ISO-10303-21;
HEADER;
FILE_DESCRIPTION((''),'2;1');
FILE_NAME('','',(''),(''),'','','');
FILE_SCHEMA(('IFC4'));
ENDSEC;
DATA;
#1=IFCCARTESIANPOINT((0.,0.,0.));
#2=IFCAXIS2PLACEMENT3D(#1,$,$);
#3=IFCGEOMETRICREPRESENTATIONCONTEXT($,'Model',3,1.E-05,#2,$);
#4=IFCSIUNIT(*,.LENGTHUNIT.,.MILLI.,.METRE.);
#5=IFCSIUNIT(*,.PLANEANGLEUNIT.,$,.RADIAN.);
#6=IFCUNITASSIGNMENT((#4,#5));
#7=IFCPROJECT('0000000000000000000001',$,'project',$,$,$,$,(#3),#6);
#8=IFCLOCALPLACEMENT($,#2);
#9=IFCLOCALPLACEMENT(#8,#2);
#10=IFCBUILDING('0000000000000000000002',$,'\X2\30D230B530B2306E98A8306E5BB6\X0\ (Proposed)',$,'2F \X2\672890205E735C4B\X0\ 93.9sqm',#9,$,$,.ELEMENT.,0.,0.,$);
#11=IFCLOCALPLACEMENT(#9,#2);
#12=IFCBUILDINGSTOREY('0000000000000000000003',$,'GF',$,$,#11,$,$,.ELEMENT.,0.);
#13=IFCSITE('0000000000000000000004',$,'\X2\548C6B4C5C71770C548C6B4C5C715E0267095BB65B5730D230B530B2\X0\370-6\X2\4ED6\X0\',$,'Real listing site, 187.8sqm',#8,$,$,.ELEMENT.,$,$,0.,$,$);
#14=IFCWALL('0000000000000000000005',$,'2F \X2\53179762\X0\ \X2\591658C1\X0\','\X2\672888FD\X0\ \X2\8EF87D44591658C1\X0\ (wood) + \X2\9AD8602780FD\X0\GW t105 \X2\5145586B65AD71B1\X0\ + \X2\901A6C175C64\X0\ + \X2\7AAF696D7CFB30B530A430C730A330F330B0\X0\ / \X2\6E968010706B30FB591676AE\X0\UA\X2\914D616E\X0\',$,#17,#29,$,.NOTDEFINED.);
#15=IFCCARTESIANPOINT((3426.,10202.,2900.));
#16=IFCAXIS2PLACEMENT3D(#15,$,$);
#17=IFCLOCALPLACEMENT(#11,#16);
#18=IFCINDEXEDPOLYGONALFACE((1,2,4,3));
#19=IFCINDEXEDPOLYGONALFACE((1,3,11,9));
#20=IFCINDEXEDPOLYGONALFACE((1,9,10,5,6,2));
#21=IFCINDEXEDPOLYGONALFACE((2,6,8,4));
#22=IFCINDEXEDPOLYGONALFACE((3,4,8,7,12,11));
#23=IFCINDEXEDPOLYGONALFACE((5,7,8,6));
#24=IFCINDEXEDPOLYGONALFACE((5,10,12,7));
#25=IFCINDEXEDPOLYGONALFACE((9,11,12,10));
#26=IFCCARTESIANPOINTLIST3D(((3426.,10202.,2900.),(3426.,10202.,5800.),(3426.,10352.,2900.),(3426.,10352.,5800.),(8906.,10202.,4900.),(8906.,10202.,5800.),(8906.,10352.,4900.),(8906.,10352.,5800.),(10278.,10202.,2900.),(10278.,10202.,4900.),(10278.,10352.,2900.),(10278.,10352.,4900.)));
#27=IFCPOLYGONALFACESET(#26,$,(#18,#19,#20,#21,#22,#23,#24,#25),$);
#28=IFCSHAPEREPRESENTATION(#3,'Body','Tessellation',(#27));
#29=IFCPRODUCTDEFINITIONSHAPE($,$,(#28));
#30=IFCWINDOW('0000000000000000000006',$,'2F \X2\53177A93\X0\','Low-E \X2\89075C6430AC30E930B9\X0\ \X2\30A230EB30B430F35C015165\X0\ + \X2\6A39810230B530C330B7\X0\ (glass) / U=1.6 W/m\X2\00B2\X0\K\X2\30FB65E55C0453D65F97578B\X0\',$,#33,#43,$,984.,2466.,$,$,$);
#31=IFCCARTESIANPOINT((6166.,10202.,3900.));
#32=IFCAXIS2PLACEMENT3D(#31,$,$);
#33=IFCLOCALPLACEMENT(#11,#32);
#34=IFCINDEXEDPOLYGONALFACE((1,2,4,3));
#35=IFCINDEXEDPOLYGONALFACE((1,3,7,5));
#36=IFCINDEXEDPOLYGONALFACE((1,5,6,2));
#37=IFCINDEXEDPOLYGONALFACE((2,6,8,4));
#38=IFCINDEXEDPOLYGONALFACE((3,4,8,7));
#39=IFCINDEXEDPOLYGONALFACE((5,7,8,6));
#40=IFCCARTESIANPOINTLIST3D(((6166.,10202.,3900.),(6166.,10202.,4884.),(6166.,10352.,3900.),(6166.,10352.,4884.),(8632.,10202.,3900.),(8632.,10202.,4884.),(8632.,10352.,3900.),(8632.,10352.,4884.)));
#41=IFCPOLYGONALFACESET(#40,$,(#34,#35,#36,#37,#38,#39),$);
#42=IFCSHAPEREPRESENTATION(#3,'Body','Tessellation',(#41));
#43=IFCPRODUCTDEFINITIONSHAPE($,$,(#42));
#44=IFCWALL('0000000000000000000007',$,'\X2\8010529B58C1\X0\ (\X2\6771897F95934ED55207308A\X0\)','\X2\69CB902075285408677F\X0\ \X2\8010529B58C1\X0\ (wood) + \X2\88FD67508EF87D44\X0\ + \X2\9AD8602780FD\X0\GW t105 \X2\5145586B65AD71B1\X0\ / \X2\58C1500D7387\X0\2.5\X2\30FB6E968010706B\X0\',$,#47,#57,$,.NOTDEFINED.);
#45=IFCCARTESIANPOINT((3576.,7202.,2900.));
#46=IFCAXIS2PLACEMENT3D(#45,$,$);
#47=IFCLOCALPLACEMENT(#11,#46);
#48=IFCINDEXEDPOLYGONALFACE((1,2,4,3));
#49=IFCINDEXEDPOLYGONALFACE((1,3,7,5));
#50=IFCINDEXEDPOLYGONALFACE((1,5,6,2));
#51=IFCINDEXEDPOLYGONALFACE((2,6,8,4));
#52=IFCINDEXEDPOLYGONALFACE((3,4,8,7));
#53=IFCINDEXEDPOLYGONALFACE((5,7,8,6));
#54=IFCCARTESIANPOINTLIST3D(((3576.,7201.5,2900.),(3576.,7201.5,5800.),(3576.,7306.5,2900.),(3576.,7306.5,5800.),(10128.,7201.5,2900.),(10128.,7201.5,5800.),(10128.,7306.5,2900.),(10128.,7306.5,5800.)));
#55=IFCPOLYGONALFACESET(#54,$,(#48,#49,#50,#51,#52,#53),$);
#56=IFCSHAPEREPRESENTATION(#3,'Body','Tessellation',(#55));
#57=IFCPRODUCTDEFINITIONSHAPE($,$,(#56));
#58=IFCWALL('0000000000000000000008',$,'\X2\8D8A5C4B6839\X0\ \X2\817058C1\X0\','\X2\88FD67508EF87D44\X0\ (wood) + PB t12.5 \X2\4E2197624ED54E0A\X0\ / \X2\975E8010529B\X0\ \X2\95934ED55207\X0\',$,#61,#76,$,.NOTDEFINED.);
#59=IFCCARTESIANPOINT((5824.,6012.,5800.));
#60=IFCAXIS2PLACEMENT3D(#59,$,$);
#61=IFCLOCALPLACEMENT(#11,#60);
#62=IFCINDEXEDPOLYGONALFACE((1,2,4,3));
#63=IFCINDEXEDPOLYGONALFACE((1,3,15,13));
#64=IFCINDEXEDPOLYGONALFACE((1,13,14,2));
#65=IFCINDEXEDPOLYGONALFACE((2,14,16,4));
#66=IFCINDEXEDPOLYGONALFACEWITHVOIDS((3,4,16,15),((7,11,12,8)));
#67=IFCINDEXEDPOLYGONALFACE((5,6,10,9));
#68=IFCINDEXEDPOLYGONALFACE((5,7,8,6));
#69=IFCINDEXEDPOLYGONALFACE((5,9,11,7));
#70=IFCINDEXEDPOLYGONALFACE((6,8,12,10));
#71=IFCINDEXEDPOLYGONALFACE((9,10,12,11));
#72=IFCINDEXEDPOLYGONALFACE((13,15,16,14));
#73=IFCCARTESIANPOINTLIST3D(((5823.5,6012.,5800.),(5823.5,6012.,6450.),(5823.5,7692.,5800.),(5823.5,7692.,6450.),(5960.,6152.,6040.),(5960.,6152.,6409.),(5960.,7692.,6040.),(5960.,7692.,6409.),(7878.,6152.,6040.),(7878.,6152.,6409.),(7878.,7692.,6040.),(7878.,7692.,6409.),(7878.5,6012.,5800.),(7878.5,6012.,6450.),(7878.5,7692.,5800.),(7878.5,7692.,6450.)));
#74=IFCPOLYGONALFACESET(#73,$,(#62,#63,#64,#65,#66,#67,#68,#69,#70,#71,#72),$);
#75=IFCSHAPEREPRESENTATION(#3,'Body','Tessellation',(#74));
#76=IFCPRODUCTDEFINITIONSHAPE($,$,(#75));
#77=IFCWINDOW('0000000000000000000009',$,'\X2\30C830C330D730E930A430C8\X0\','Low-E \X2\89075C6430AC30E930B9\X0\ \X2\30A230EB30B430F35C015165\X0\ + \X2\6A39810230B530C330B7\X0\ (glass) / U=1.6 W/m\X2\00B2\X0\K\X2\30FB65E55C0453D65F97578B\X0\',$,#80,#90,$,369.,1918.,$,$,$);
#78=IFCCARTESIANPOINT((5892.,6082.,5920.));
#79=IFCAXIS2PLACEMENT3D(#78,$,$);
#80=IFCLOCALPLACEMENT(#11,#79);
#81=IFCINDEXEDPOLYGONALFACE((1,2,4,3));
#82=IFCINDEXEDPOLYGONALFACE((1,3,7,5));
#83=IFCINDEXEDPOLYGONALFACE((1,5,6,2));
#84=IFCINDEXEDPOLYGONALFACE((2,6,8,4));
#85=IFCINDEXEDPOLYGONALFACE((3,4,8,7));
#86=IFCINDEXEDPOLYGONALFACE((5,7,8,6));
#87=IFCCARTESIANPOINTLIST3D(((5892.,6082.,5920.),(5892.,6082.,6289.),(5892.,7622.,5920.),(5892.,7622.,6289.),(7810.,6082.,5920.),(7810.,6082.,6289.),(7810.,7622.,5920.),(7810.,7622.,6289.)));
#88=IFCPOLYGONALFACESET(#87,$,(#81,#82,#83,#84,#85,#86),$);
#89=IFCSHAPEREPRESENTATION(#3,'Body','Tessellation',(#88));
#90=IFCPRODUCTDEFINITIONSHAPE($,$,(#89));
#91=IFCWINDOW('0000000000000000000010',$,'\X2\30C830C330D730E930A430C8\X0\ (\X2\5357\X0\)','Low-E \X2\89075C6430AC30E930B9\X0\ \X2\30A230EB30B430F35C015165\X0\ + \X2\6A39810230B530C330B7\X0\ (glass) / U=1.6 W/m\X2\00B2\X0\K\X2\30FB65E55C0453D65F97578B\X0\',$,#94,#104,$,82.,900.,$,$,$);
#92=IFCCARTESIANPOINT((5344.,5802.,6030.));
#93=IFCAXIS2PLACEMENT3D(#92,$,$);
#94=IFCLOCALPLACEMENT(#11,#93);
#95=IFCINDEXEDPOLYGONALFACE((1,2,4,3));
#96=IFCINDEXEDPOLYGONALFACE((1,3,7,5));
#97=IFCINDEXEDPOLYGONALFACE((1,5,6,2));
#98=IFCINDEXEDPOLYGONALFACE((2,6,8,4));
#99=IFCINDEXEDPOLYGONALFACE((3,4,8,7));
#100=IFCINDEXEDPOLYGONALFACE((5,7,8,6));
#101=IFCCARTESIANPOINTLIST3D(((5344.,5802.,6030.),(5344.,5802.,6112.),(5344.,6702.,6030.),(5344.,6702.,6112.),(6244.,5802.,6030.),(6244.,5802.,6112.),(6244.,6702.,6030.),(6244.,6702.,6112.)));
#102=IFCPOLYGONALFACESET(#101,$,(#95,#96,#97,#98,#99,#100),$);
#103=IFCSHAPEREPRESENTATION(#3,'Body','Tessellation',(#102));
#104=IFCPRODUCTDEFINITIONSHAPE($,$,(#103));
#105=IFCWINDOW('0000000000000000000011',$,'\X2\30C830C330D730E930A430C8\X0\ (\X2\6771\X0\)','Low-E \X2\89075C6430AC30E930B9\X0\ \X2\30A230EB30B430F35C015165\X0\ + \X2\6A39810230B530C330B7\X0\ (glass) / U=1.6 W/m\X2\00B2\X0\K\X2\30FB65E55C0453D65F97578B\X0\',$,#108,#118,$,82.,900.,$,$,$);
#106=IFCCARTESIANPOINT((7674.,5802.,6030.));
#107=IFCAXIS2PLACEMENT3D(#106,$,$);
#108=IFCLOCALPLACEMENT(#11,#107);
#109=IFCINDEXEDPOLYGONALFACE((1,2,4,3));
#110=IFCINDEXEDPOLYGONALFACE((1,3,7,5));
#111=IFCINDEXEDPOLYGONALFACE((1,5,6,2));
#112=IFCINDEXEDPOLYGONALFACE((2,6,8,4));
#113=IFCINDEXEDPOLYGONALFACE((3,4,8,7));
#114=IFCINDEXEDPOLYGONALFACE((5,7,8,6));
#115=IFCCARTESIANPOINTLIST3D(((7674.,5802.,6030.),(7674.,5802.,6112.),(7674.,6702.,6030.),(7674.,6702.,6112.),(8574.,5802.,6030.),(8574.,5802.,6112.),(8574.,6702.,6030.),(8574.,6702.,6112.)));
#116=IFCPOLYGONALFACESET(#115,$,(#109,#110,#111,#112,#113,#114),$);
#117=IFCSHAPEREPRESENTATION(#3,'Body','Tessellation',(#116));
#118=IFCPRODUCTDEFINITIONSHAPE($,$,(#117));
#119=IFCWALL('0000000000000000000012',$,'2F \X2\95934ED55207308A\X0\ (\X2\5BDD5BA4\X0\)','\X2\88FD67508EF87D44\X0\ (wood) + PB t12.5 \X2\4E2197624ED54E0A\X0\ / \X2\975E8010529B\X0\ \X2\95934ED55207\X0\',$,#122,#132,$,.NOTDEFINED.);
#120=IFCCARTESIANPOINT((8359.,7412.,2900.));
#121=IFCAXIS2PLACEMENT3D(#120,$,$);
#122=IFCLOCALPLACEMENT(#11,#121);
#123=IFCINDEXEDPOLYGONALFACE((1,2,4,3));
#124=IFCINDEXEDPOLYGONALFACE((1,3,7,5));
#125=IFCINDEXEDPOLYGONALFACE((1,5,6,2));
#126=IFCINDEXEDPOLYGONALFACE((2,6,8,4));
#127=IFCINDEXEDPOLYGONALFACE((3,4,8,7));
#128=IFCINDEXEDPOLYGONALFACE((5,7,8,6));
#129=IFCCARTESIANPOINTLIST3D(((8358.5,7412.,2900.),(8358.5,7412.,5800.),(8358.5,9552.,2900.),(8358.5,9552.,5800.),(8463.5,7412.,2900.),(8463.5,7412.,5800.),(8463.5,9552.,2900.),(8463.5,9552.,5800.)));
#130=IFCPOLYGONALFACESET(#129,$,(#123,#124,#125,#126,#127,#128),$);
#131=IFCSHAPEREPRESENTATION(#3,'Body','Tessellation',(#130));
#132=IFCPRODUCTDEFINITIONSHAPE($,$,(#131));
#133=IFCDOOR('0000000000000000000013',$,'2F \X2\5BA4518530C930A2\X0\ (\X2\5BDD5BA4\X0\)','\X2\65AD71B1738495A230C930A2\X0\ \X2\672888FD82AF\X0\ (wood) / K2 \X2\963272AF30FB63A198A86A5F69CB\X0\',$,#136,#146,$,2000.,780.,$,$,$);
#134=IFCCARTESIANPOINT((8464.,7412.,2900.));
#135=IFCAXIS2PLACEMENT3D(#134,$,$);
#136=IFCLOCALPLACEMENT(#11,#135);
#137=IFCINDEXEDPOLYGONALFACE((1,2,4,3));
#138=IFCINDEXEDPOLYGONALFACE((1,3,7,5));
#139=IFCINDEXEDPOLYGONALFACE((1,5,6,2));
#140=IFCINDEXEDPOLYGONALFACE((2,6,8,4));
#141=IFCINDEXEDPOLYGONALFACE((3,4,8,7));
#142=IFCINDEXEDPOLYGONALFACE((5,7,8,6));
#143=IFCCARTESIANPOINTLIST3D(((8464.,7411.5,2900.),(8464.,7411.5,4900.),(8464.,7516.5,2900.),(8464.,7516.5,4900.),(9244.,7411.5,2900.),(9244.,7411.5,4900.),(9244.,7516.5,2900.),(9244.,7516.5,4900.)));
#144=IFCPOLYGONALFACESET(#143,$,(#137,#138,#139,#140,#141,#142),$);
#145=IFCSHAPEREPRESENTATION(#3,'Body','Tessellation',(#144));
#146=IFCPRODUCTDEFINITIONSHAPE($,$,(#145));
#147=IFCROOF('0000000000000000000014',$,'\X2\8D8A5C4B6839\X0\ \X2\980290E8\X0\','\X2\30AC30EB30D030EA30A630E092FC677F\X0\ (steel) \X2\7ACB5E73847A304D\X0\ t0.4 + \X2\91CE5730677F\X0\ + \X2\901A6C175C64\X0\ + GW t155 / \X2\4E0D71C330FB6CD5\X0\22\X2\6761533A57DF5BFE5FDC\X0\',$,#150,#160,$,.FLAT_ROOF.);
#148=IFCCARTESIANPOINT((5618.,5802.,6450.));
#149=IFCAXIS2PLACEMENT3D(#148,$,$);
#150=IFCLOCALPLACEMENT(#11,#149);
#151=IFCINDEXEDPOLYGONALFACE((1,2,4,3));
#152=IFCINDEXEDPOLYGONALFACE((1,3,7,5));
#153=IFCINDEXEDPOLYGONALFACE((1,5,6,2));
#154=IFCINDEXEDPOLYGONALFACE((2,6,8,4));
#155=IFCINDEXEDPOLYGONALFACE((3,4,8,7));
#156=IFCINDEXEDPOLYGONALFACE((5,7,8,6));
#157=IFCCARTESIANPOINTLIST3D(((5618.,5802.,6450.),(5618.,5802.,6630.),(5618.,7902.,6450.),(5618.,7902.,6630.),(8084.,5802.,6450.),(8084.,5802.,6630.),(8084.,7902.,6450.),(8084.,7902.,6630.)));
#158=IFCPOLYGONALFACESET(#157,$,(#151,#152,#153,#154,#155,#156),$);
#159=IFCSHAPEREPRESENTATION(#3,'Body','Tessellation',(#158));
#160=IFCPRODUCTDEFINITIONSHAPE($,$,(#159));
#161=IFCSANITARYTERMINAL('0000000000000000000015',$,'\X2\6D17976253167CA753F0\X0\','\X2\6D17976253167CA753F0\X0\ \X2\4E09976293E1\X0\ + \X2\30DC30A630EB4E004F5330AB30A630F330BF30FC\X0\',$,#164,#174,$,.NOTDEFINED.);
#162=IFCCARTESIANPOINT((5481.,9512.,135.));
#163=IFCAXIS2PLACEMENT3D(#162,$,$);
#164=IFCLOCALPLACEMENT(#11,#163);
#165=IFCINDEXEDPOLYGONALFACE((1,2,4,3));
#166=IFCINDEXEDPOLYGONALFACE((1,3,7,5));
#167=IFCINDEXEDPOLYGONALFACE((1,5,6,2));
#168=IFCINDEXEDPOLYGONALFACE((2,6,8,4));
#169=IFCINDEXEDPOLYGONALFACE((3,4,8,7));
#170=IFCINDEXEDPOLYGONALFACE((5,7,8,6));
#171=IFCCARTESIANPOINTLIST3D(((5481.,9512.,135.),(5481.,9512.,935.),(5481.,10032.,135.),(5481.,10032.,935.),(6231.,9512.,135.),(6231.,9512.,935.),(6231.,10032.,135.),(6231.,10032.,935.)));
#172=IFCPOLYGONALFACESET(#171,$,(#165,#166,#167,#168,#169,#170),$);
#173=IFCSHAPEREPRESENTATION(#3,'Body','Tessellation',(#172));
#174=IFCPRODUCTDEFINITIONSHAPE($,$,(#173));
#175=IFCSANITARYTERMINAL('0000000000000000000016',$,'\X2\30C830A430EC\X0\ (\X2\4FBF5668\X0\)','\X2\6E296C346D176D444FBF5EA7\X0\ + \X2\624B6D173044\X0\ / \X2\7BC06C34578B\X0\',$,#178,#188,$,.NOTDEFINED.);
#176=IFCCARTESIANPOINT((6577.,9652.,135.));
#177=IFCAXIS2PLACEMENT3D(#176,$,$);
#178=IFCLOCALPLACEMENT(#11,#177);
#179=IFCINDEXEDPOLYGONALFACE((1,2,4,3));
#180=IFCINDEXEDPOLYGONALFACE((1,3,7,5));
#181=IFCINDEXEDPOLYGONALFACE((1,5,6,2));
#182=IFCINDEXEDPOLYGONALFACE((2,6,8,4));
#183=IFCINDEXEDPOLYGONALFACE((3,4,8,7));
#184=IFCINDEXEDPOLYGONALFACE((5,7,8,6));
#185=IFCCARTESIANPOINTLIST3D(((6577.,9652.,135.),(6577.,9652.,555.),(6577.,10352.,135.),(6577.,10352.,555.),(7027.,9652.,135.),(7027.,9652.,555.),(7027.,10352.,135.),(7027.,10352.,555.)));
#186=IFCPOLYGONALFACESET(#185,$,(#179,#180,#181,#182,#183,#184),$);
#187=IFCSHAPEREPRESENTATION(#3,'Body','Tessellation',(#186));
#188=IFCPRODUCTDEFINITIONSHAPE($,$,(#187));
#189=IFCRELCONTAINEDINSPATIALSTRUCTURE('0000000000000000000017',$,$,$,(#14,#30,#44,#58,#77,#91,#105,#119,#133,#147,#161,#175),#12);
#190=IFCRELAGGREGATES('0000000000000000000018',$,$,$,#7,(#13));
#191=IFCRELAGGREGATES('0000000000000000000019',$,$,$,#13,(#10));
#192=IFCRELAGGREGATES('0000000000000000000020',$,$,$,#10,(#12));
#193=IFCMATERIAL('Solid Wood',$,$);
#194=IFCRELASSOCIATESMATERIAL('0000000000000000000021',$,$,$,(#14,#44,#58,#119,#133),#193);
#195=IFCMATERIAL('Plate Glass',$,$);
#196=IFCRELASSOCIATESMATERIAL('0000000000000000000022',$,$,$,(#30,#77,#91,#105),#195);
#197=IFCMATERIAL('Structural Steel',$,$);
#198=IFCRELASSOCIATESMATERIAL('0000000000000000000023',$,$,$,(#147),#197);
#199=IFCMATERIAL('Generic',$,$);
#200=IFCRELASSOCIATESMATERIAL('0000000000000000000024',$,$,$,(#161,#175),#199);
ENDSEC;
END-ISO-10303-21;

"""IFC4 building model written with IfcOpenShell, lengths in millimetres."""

from ifc_helpers import new_model, si_unit, frame, frame_2d, origin, place, context, project, spatial, rectangle, extrude, material, element, fill, save


model = new_model("IFC4")

# Units and contexts
model_context = context("Model", 3, precision=1e-05, world=origin())
ifc_project = project(units=[si_unit("LENGTHUNIT", "METRE", prefix="MILLI"), si_unit("PLANEANGLEUNIT", "RADIAN")], contexts=[model_context])

# Site, building, storey
site_placement = place(None, origin())
site = spatial("IfcSite", under=ifc_project, at=site_placement, Name="和歌山県和歌山市有家字ヒサゲ370-6他", ObjectType="Real listing site, 187.8sqm", CompositionType="ELEMENT", RefElevation=0.0)
building_placement = place(site_placement, origin())
building = spatial("IfcBuilding", under=site, at=building_placement, Name="ヒサゲの風の家 (Proposed)", ObjectType="2F 木造平屋 93.9sqm", CompositionType="ELEMENT", ElevationOfRefHeight=0.0, ElevationOfTerrain=0.0)
storey_placement = place(building_placement, origin())
storey = spatial("IfcBuildingStorey", under=building, at=storey_placement, Name="GF", CompositionType="ELEMENT", Elevation=0.0)

# Wall, opening, window
ifc_material_1 = material(Name="Solid Wood")
wall_1_placement = place(storey_placement, frame((3426.0, 10202.0, 2900.0)))
wall_1 = element("IfcWall", 1, at=wall_1_placement, inside=storey, material=ifc_material_1, Name="2F 北面 外壁", Description="木製 軸組外壁 (wood) + 高性能GW t105 充填断熱 + 通気層 + 窯業系サイディング / 準耐火・外皮UA配慮", PredefinedType="NOTDEFINED", context=model_context, shape_type="SweptSolid", body=[
    extrude(rectangle(XDim=6852.0, YDim=150.0, at=frame_2d((3426.0, 75.0))), frame((3426.0, 10202.0, 2900.0)), (0.0, 0.0, 1.0), 2900.0),
])
opening_1_placement = place(storey_placement, frame((6166.0, 10202.0, 3900.0)))
opening_1 = element("IfcOpeningElement", 2, at=opening_1_placement, cuts=wall_1, PredefinedType="NOTDEFINED", context=model_context, shape_type="SweptSolid", body=[
    extrude(rectangle(XDim=2466.0, YDim=150.0, at=frame_2d((1233.0, 75.0))), frame((6166.0, 10202.0, 3900.0)), (0.0, 0.0, 1.0), 984.0),
])
ifc_material_2 = material(Name="Plate Glass")
window_1_placement = place(storey_placement, frame((6166.0, 10202.0, 3900.0)))
window_1 = element("IfcWindow", 3, at=window_1_placement, inside=storey, material=ifc_material_2, Name="2F 北窓", Description="Low-E 複層ガラス アルゴン封入 + 樹脂サッシ (glass) / U=1.6 W/m²K・日射取得型", OverallHeight=984.0, OverallWidth=2466.0, context=model_context, shape_type="SweptSolid", body=[
    extrude(rectangle(XDim=2466.0, YDim=150.0, at=frame_2d((1233.0, 75.0))), frame((6166.0, 10202.0, 3900.0)), (0.0, 0.0, 1.0), 984.0),
])
fill(opening_1, window_1)

# Wall
wall_2_placement = place(storey_placement, frame((3576.0, 7202.0, 2900.0)))
element("IfcWall", 4, at=wall_2_placement, inside=storey, material=ifc_material_1, Name="耐力壁 (東西間仕切り)", Description="構造用合板 耐力壁 (wood) + 製材軸組 + 高性能GW t105 充填断熱 / 壁倍率2.5・準耐火", PredefinedType="NOTDEFINED", context=model_context, shape_type="SweptSolid", body=[
    extrude(rectangle(XDim=6552.0, YDim=105.0, at=frame_2d((3276.0, 52.0))), frame((3576.0, 7202.0, 2900.0)), (0.0, 0.0, 1.0), 2900.0),
])

# Wall, openings, windows
wall_3_placement = place(storey_placement, frame((5824.0, 6012.0, 5800.0)))
wall_3 = element("IfcWall", 5, at=wall_3_placement, inside=storey, material=ifc_material_1, Name="越屋根 腰壁", Description="製材軸組 (wood) + PB t12.5 両面仕上 / 非耐力 間仕切", PredefinedType="NOTDEFINED", context=model_context, shape_type="SweptSolid", body=[
    extrude(rectangle(XDim=2055.0, YDim=1680.0, at=frame_2d((1027.0, 840.0))), frame((5824.0, 6012.0, 5800.0)), (0.0, 0.0, 1.0), 650.0),
])
opening_2_placement = place(storey_placement, frame((5892.0, 6082.0, 5920.0)))
opening_2 = element("IfcOpeningElement", 6, at=opening_2_placement, cuts=wall_3, PredefinedType="NOTDEFINED", context=model_context, shape_type="SweptSolid", body=[
    extrude(rectangle(XDim=1918.0, YDim=1540.0, at=frame_2d((959.0, 770.0))), frame((5892.0, 6082.0, 5920.0)), (0.0, 0.0, 1.0), 369.0),
])
opening_3_placement = place(storey_placement, frame((5344.0, 5802.0, 6030.0)))
opening_3 = element("IfcOpeningElement", 7, at=opening_3_placement, cuts=wall_3, PredefinedType="NOTDEFINED", context=model_context, shape_type="SweptSolid", body=[
    extrude(rectangle(XDim=900.0, YDim=900.0, at=frame_2d((450.0, 450.0))), frame((5344.0, 5802.0, 6030.0)), (0.0, 0.0, 1.0), 82.0),
])
opening_4_placement = place(storey_placement, frame((7674.0, 5802.0, 6030.0)))
opening_4 = element("IfcOpeningElement", 8, at=opening_4_placement, cuts=wall_3, PredefinedType="NOTDEFINED", context=model_context, shape_type="SweptSolid", body=[
    extrude(rectangle(XDim=900.0, YDim=900.0, at=frame_2d((450.0, 450.0))), frame((7674.0, 5802.0, 6030.0)), (0.0, 0.0, 1.0), 82.0),
])
window_2_placement = place(storey_placement, frame((5892.0, 6082.0, 5920.0)))
window_2 = element("IfcWindow", 9, at=window_2_placement, inside=storey, material=ifc_material_2, Name="トップライト", Description="Low-E 複層ガラス アルゴン封入 + 樹脂サッシ (glass) / U=1.6 W/m²K・日射取得型", OverallHeight=369.0, OverallWidth=1918.0, context=model_context, shape_type="SweptSolid", body=[
    extrude(rectangle(XDim=1918.0, YDim=1540.0, at=frame_2d((959.0, 770.0))), frame((5892.0, 6082.0, 5920.0)), (0.0, 0.0, 1.0), 369.0),
])
fill(opening_2, window_2)
window_3_placement = place(storey_placement, frame((5344.0, 5802.0, 6030.0)))
window_3 = element("IfcWindow", 10, at=window_3_placement, inside=storey, material=ifc_material_2, Name="トップライト (南)", Description="Low-E 複層ガラス アルゴン封入 + 樹脂サッシ (glass) / U=1.6 W/m²K・日射取得型", OverallHeight=82.0, OverallWidth=900.0, context=model_context, shape_type="SweptSolid", body=[
    extrude(rectangle(XDim=900.0, YDim=900.0, at=frame_2d((450.0, 450.0))), frame((5344.0, 5802.0, 6030.0)), (0.0, 0.0, 1.0), 82.0),
])
fill(opening_3, window_3)
window_4_placement = place(storey_placement, frame((7674.0, 5802.0, 6030.0)))
window_4 = element("IfcWindow", 11, at=window_4_placement, inside=storey, material=ifc_material_2, Name="トップライト (東)", Description="Low-E 複層ガラス アルゴン封入 + 樹脂サッシ (glass) / U=1.6 W/m²K・日射取得型", OverallHeight=82.0, OverallWidth=900.0, context=model_context, shape_type="SweptSolid", body=[
    extrude(rectangle(XDim=900.0, YDim=900.0, at=frame_2d((450.0, 450.0))), frame((7674.0, 5802.0, 6030.0)), (0.0, 0.0, 1.0), 82.0),
])
fill(opening_4, window_4)

# Wall
wall_4_placement = place(storey_placement, frame((8359.0, 7412.0, 2900.0)))
element("IfcWall", 12, at=wall_4_placement, inside=storey, material=ifc_material_1, Name="2F 間仕切り (寝室)", Description="製材軸組 (wood) + PB t12.5 両面仕上 / 非耐力 間仕切", PredefinedType="NOTDEFINED", context=model_context, shape_type="SweptSolid", body=[
    extrude(rectangle(XDim=105.0, YDim=2140.0, at=frame_2d((52.0, 1070.0))), frame((8359.0, 7412.0, 2900.0)), (0.0, 0.0, 1.0), 2900.0),
])

# Door
door_placement = place(storey_placement, frame((8464.0, 7412.0, 2900.0)))
element("IfcDoor", 13, at=door_placement, inside=storey, material=ifc_material_1, Name="2F 室内ドア (寝室)", Description="断熱玄関ドア 木製芯 (wood) / K2 防犯・採風機構", OverallHeight=2000.0, OverallWidth=780.0, context=model_context, shape_type="SweptSolid", body=[
    extrude(rectangle(XDim=780.0, YDim=105.0, at=frame_2d((390.0, 52.0))), frame((8464.0, 7412.0, 2900.0)), (0.0, 0.0, 1.0), 2000.0),
])

# Roof
ifc_material_3 = material(Name="Structural Steel")
roof_placement = place(storey_placement, frame((5618.0, 5802.0, 6450.0)))
element("IfcRoof", 14, at=roof_placement, inside=storey, material=ifc_material_3, Name="越屋根 頂部", Description="ガルバリウム鋼板 (steel) 立平葺き t0.4 + 野地板 + 通気層 + GW t155 / 不燃・法22条区域対応", PredefinedType="FLAT_ROOF", context=model_context, shape_type="SweptSolid", body=[
    extrude(rectangle(XDim=2466.0, YDim=2100.0, at=frame_2d((1233.0, 1050.0))), frame((5618.0, 5802.0, 6450.0)), (0.0, 0.0, 1.0), 180.0),
])

# Sanitary terminals
ifc_material_4 = material(Name="Generic")
sanitary_terminal_1_placement = place(storey_placement, frame((5481.0, 9512.0, 135.0)))
element("IfcSanitaryTerminal", 15, at=sanitary_terminal_1_placement, inside=storey, material=ifc_material_4, Name="洗面化粧台", Description="洗面化粧台 三面鏡 + ボウル一体カウンター", PredefinedType="NOTDEFINED", context=model_context, shape_type="SweptSolid", body=[
    extrude(rectangle(XDim=750.0, YDim=520.0, at=frame_2d((375.0, 260.0))), frame((5481.0, 9512.0, 135.0)), (0.0, 0.0, 1.0), 800.0),
])
sanitary_terminal_2_placement = place(storey_placement, frame((6577.0, 9652.0, 135.0)))
element("IfcSanitaryTerminal", 16, at=sanitary_terminal_2_placement, inside=storey, material=ifc_material_4, Name="トイレ (便器)", Description="温水洗浄便座 + 手洗い / 節水型", PredefinedType="NOTDEFINED", context=model_context, shape_type="SweptSolid", body=[
    extrude(rectangle(XDim=450.0, YDim=700.0, at=frame_2d((225.0, 350.0))), frame((6577.0, 9652.0, 135.0)), (0.0, 0.0, 1.0), 420.0),
])

save(model, "model.ifc")
